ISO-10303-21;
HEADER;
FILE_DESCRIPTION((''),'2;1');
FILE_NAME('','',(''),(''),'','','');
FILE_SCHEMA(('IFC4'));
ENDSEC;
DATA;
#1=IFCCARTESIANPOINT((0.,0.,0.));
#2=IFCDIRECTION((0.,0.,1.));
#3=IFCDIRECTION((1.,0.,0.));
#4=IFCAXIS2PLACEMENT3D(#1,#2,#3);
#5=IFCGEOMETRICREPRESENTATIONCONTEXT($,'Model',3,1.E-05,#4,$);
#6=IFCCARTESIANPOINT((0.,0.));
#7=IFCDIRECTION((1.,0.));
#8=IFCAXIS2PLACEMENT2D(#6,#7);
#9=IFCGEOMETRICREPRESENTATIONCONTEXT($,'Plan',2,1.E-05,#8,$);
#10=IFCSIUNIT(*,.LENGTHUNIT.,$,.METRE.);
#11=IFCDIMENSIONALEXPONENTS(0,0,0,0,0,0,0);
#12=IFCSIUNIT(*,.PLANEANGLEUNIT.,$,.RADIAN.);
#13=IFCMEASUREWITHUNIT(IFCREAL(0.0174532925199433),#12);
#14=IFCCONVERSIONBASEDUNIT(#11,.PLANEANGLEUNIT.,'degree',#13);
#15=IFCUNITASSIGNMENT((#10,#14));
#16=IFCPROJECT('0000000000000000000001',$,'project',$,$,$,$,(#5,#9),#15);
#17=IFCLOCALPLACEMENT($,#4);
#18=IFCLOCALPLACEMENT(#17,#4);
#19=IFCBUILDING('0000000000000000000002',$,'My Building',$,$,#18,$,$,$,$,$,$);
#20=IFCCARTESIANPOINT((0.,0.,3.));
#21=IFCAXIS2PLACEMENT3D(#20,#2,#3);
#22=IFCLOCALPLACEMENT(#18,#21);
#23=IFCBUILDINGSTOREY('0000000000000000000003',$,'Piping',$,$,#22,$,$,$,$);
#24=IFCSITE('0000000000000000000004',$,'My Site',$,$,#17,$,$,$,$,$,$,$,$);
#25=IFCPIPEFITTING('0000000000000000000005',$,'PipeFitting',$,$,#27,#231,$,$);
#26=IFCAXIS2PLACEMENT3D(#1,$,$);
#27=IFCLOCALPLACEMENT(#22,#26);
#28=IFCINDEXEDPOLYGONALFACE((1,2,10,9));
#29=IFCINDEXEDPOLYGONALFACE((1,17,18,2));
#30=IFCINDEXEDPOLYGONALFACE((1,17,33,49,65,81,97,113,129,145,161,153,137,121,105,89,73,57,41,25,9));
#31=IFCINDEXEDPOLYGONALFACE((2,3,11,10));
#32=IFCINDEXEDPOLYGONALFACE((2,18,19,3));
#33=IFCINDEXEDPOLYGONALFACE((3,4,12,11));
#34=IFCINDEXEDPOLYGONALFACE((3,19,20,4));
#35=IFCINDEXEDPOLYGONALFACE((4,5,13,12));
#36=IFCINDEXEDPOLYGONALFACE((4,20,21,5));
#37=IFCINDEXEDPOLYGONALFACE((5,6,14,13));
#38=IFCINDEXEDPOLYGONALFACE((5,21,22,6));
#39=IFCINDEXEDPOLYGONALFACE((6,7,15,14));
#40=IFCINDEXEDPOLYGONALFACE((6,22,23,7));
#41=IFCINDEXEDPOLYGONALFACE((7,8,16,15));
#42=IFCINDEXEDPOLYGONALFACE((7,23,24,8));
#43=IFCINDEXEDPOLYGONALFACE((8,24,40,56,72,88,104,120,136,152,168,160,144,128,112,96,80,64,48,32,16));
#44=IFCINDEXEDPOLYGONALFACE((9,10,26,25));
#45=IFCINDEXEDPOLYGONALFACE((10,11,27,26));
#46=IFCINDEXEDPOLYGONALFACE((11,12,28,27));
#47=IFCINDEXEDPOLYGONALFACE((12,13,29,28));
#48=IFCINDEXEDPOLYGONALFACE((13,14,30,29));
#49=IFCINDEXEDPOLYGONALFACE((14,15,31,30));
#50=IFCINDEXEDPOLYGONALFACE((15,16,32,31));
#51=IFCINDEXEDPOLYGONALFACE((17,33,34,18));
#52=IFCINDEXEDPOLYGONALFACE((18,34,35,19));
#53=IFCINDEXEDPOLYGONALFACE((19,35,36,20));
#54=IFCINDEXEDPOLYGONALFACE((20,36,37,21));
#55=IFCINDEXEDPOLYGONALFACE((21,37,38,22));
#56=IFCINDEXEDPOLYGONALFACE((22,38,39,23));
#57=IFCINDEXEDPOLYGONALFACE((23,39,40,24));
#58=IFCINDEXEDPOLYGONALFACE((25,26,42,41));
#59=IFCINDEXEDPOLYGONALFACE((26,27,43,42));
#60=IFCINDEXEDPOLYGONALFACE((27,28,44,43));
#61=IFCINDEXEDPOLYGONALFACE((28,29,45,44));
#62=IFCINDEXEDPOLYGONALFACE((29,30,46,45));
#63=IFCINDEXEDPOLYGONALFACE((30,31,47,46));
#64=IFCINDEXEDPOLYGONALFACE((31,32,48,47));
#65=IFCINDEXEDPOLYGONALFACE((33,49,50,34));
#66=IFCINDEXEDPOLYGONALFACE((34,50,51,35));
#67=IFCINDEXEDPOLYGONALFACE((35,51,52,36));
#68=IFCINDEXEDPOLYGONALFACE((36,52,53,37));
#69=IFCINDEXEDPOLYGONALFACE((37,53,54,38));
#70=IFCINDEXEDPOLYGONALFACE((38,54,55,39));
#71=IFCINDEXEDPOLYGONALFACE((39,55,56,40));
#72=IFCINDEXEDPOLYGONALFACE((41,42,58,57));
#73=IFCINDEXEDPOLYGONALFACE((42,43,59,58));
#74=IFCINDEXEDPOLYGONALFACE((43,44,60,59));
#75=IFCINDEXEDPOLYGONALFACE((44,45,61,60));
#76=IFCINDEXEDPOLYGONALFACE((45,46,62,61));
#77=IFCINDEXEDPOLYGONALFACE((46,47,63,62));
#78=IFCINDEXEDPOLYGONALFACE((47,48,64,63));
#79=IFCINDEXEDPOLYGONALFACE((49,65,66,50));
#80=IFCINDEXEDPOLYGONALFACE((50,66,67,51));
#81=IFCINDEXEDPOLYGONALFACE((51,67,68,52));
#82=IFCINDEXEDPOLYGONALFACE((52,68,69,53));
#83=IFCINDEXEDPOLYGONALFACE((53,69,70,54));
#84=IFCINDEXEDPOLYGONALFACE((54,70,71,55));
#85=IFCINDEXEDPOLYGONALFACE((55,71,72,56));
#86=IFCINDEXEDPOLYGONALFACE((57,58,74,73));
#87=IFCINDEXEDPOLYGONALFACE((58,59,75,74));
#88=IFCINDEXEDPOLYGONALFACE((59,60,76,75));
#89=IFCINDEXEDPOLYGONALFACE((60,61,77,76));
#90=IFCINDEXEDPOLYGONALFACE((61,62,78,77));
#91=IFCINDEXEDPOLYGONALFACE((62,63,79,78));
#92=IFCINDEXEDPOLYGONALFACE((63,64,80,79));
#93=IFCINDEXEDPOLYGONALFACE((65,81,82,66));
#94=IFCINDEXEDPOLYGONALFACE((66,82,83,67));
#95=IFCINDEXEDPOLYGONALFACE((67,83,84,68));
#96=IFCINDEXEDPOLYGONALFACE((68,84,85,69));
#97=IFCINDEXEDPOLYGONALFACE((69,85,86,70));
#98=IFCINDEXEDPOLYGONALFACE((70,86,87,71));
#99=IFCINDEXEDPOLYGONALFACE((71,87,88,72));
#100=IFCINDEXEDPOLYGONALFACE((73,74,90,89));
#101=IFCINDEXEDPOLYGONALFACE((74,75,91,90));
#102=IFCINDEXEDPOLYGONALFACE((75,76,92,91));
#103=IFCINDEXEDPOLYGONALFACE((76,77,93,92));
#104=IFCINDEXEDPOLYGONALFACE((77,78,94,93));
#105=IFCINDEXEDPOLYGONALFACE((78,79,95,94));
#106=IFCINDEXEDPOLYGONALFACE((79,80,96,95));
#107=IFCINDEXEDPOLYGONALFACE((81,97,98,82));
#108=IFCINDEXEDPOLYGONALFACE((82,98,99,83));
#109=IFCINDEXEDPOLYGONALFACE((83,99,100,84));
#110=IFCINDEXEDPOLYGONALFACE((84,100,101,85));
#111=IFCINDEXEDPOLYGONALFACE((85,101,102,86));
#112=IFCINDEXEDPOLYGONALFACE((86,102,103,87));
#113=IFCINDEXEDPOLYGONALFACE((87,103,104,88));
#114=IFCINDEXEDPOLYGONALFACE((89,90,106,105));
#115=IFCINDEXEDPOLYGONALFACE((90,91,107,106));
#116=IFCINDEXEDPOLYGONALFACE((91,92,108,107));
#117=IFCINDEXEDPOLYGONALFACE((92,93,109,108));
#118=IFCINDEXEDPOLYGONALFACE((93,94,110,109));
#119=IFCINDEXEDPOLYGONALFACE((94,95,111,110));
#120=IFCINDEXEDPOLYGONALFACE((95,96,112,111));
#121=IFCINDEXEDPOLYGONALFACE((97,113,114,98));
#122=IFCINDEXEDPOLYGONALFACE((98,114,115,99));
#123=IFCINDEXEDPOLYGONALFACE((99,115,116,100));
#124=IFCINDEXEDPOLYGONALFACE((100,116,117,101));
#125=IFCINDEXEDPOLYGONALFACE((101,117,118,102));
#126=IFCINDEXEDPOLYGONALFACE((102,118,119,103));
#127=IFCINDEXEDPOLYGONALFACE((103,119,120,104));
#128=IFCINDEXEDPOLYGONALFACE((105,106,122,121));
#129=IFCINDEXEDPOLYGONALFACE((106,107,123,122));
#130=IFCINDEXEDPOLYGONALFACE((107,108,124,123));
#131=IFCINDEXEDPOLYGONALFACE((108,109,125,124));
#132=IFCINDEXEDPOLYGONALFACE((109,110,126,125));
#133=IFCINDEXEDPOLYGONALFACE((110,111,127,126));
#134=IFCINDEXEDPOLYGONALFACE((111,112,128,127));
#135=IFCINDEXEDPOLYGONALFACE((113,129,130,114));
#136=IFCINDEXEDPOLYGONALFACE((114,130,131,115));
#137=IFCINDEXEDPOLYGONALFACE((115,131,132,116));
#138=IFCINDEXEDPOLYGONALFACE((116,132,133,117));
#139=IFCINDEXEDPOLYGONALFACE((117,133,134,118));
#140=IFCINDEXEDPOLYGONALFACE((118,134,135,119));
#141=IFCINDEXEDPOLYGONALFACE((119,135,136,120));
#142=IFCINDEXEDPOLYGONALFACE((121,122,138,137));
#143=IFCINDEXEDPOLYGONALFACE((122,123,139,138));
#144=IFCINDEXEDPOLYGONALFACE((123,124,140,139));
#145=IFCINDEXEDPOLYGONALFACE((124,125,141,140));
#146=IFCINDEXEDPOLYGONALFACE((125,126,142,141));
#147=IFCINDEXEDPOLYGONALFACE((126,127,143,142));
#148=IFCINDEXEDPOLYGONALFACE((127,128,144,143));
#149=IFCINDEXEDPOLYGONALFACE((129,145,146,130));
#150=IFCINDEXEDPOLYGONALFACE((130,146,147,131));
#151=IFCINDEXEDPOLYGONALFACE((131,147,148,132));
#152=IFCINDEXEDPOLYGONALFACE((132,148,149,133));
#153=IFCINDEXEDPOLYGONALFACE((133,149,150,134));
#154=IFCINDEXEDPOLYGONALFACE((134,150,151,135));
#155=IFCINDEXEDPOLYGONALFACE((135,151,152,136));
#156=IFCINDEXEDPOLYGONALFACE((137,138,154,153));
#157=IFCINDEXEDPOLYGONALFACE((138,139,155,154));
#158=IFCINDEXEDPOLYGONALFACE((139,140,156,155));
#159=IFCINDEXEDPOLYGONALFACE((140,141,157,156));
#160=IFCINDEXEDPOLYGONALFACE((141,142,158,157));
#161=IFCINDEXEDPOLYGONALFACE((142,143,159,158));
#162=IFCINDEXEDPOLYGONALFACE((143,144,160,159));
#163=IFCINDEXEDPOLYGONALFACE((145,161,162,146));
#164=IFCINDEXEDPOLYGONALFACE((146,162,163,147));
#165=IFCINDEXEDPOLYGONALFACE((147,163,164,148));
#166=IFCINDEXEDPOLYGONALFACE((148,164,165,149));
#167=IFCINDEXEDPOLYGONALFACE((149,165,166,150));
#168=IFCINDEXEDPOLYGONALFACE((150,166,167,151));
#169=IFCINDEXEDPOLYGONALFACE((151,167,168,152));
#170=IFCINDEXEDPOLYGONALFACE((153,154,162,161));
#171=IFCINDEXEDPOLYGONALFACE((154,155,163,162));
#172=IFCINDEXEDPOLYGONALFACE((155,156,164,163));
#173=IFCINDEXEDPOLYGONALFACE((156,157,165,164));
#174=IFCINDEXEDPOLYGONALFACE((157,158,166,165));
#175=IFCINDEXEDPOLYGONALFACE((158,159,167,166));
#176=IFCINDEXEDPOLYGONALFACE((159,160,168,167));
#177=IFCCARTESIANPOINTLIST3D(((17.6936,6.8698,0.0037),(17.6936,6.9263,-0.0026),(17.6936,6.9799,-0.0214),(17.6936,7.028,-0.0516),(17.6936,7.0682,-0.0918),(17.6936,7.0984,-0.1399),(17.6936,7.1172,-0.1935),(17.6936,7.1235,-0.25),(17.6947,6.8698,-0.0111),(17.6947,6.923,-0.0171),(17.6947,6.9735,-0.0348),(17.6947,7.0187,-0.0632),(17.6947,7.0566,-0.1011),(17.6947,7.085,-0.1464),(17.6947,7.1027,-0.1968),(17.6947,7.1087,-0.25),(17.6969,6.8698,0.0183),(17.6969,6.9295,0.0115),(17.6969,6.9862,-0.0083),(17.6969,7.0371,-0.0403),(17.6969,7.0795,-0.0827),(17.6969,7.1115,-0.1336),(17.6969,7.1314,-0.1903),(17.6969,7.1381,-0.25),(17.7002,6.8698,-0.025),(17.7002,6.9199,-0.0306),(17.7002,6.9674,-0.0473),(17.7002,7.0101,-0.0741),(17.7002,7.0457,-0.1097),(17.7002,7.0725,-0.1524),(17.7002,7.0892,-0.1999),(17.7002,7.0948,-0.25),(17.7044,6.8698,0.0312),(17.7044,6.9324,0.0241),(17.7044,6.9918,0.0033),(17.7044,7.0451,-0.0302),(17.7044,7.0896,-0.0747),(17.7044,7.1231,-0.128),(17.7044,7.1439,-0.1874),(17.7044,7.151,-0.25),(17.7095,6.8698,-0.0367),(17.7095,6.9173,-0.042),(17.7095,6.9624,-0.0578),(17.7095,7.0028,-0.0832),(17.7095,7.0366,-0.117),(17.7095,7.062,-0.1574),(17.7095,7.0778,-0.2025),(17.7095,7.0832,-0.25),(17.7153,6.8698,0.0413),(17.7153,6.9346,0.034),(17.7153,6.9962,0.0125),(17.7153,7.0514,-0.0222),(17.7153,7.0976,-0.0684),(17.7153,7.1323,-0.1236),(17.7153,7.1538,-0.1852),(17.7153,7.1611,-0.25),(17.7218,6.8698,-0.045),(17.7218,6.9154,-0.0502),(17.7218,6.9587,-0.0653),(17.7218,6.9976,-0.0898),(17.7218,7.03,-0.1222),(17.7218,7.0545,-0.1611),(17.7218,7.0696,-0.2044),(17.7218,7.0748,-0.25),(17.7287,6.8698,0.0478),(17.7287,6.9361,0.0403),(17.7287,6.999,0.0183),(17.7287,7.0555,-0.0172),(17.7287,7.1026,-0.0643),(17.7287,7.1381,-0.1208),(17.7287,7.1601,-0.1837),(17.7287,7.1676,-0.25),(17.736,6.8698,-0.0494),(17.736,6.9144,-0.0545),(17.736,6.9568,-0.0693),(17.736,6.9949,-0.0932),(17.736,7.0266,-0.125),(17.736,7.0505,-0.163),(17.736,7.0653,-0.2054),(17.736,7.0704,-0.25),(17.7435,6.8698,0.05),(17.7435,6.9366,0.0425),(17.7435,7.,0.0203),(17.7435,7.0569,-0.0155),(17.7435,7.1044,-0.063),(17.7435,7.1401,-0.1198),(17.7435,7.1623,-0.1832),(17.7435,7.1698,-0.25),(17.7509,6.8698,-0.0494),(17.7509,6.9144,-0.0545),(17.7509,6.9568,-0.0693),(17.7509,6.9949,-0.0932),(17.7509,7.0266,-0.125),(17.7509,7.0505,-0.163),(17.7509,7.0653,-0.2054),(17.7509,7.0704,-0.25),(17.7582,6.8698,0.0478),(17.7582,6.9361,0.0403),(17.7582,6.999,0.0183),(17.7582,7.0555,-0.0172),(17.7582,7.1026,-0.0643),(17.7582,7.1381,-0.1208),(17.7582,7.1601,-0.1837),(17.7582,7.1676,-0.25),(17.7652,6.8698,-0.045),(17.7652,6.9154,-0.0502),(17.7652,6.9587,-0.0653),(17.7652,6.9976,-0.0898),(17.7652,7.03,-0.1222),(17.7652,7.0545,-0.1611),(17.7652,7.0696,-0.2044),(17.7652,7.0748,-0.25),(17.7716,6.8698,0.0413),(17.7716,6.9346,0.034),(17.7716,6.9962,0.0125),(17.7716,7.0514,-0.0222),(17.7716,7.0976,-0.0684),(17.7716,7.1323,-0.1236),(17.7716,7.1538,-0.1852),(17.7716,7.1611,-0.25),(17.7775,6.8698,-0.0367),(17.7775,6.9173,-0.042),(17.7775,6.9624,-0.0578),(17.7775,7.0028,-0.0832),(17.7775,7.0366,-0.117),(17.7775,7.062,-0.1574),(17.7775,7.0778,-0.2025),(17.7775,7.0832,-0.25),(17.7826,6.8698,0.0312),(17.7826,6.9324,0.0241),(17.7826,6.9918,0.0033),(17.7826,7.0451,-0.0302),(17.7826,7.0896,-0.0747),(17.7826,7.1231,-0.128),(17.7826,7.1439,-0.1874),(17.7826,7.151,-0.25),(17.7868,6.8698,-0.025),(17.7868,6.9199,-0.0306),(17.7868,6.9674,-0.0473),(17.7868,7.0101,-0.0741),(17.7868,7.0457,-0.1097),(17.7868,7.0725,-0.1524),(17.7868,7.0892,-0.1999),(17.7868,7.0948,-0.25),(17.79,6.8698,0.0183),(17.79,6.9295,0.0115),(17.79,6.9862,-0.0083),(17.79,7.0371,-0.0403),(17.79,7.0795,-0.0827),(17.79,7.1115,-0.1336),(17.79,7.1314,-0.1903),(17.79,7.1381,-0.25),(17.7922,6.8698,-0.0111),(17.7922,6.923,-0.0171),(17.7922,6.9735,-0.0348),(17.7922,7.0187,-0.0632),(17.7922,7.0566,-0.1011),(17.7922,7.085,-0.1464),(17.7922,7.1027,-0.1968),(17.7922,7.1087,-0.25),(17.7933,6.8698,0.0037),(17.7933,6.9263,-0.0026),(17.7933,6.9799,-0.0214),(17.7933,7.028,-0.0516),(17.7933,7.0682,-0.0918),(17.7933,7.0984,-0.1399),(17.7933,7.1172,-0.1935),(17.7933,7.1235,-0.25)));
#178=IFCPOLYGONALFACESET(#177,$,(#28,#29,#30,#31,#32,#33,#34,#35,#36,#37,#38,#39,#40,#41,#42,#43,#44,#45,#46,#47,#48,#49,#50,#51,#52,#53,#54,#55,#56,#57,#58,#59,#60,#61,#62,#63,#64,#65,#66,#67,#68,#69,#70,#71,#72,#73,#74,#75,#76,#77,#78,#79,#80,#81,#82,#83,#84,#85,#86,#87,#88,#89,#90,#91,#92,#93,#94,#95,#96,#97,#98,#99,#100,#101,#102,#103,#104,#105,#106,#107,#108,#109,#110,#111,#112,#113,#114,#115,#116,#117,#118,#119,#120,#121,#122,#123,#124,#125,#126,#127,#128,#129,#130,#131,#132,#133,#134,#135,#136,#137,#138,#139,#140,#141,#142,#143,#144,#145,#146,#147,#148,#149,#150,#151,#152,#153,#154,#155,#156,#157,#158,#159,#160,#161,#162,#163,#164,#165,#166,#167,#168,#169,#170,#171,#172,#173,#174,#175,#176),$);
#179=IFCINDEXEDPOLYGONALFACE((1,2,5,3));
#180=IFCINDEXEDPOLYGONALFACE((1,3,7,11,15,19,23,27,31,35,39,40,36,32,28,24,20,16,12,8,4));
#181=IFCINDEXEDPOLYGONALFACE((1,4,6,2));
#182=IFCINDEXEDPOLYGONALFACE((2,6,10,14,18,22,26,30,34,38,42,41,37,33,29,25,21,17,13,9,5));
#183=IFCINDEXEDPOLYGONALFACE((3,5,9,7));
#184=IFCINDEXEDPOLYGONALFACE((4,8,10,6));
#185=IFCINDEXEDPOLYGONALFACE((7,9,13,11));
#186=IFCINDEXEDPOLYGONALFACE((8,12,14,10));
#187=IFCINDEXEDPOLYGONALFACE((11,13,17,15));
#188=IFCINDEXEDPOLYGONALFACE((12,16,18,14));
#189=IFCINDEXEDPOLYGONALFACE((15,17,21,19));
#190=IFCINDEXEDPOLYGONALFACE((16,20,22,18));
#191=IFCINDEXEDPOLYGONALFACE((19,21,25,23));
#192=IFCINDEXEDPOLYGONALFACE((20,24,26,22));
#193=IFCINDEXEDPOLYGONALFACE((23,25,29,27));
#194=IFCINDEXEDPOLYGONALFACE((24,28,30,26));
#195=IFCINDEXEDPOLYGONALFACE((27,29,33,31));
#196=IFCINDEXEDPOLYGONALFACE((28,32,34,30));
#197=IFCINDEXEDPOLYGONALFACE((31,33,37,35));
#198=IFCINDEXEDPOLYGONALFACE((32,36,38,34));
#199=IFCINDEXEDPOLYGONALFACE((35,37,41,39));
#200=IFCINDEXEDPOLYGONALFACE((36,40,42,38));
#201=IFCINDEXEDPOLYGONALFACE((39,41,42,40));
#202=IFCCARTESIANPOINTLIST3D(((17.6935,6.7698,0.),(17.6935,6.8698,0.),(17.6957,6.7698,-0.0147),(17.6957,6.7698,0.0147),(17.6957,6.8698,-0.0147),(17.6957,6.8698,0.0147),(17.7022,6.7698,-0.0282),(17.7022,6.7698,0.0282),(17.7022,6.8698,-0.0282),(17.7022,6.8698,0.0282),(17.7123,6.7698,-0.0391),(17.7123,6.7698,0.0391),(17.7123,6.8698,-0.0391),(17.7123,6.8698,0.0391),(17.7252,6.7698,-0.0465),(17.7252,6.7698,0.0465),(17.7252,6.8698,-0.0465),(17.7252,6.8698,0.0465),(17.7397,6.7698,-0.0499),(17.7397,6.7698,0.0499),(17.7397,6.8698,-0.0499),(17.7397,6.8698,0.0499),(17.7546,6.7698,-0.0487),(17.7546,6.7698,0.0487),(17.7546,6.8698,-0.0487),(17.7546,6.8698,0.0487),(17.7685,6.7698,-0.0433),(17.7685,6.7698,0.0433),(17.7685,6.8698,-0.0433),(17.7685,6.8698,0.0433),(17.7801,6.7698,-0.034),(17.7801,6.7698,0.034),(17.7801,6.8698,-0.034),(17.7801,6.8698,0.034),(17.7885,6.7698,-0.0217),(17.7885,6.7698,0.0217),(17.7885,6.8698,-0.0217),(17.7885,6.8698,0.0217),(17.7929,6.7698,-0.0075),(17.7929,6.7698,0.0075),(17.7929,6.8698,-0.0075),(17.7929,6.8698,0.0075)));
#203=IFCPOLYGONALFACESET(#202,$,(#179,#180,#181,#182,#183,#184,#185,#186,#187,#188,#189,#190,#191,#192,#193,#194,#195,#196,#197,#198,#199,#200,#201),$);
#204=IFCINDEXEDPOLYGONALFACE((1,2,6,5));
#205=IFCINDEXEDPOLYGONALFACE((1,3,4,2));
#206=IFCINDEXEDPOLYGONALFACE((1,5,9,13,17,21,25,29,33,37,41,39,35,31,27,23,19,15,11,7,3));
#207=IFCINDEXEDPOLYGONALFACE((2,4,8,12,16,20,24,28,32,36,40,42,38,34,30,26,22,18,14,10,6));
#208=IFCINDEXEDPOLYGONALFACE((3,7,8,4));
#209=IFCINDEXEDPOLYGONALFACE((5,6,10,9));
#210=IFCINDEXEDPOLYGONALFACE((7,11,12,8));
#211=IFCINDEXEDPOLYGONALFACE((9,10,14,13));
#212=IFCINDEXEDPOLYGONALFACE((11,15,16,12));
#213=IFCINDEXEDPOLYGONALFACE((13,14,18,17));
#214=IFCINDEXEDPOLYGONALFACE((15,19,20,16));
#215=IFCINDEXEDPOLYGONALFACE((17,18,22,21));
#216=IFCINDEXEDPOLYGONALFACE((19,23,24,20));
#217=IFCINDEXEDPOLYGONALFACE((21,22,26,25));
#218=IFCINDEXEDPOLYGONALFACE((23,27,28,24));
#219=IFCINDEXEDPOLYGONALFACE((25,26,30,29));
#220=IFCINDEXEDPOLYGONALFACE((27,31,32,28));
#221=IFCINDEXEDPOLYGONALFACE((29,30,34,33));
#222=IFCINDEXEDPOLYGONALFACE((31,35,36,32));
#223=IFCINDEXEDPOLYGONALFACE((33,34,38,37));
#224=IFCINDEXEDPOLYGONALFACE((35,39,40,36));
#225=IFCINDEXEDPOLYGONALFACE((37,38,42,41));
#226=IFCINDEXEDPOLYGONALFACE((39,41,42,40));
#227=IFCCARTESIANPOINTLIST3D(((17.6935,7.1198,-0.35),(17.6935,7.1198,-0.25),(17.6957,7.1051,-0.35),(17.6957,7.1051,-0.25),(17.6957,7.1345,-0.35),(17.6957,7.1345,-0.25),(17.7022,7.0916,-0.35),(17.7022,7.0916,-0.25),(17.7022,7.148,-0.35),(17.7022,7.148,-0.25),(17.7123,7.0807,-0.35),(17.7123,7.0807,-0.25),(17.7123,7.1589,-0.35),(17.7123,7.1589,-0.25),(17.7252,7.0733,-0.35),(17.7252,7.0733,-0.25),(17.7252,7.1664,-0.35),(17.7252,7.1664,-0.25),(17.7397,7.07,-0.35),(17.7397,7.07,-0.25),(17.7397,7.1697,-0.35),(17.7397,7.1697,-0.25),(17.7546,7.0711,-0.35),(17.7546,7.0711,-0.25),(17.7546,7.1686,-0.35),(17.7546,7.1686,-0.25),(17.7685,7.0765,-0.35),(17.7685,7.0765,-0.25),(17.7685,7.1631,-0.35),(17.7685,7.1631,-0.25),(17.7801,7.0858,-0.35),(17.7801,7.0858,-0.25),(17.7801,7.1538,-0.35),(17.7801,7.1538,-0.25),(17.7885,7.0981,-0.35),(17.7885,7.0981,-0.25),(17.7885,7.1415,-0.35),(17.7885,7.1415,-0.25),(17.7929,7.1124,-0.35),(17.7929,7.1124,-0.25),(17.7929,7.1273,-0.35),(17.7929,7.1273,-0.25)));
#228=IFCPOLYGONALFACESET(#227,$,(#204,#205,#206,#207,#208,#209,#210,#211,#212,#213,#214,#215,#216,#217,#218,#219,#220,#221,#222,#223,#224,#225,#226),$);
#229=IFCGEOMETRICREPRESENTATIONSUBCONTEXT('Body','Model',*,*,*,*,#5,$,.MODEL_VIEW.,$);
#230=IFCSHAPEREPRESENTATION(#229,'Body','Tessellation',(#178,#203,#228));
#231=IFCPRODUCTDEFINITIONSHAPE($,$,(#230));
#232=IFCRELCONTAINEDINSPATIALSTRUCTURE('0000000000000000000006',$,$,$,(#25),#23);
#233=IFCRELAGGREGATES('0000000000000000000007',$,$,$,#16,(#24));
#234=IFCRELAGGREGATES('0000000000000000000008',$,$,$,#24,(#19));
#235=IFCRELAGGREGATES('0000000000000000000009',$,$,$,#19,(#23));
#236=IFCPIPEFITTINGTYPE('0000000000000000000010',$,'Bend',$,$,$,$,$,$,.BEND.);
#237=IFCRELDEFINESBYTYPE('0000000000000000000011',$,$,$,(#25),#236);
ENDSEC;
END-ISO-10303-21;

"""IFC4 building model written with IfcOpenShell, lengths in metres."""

from ifc_helpers import new_model, entity, si_unit, converted_unit, frame, origin_with_axes, origin_2d_with_axis, place, context, subcontext, project, spatial, line, indexed_curve, circle, outline, extrude, source, transform, mapped, type_object, type_shapes, element, save


model = new_model("IFC4")

# Units and contexts
model_context = context("Model", 3, precision=1e-05, world=origin_with_axes())
plan_context = context("Plan", 2, precision=1e-05, world=origin_2d_with_axis())
body_context = subcontext(model_context, "Body", "Model", "MODEL_VIEW")
ifc_project = project(units=[si_unit("LENGTHUNIT", "METRE"), converted_unit("PLANEANGLEUNIT", "degree", entity("IfcReal", 0.0174532925199433), si_unit("PLANEANGLEUNIT", "RADIAN"), dimensions=[0, 0, 0, 0, 0, 0, 0])], contexts=[model_context, plan_context])

# Site, building, storey
site_placement = place(None, origin_with_axes())
site = spatial("IfcSite", under=ifc_project, at=site_placement, Name="My Site")
building_placement = place(site_placement, origin_with_axes())
building = spatial("IfcBuilding", under=site, at=building_placement, Name="My Building")
storey_placement = place(building_placement, frame((0.0, 0.0, 3.0), z_axis=(0.0, 0.0, 1.0), x_axis=(1.0, 0.0, 0.0)))
storey = spatial("IfcBuildingStorey", under=building, at=storey_placement, Name="Piping")

# Pipe fitting, opening
pipe_fitting_type = type_object("IfcPipeFittingType", Name="Bend", PredefinedType="BEND")
shared_shape = source(origin_with_axes(), body_context, "Body", "SolidModel", [
    entity("IfcSweptDiskSolid", entity("IfcIndexedPolyCurve", entity("IfcCartesianPointList3D", [[0.0, 0.0, 0.1], [0.0, -0.0732, 0.2768], [0.0, -0.25, 0.35]]), [entity("IfcArcIndex", [1, 2, 3])]), 0.05),
    extrude(circle(Radius=0.05), origin_with_axes(), (0.0, 0.0, 1.0), 0.1),
    extrude(circle(Radius=0.05), frame((0.0, -0.25, 0.35), z_axis=(0.0, -1.0, 0.0), x_axis=(1.0, 0.0, 0.0)), (0.0, 0.0, 1.0), 0.1),
])
type_shapes(pipe_fitting_type, [shared_shape])
pipe_fitting_1_placement = place(storey_placement, frame((17.7435, 6.7698, 0.0), z_axis=(0.0, 1.0, 0.0), x_axis=(-1.0, 0.0, 0.0)))
pipe_fitting_1 = element("IfcPipeFitting", 1, at=pipe_fitting_1_placement, inside=storey, type_object=pipe_fitting_type, Name="PipeFitting", context=body_context, shape_type="MappedRepresentation", body=[
    mapped(shared_shape, transform((0.0, 0.0, 0.0), x_axis=(1.0, 0.0, 0.0), y_axis=(0.0, 1.0, 0.0), z_axis=(0.0, 0.0, 1.0), scale=1.0)),
])
opening_1_placement = place(pipe_fitting_1_placement, frame((17.7435, -3.0, -6.7698), z_axis=(0.0, 1.0, 0.0), x_axis=(-1.0, 0.0, 0.0)))
element("IfcOpeningElement", 2, at=opening_1_placement, cuts=pipe_fitting_1, PredefinedType="OPENING", context=body_context, shape_type="SweptSolid", body=[
    extrude(outline(indexed_curve([(0.0, 0.0), (0.5, 0.0), (0.5, 0.5), (0.0, 0.5)], segments=[line(1, 2, 3, 4, 1)])), origin_with_axes(), (0.0, 0.0, 1.0), 0.5),
])

save(model, "model.ifc")
